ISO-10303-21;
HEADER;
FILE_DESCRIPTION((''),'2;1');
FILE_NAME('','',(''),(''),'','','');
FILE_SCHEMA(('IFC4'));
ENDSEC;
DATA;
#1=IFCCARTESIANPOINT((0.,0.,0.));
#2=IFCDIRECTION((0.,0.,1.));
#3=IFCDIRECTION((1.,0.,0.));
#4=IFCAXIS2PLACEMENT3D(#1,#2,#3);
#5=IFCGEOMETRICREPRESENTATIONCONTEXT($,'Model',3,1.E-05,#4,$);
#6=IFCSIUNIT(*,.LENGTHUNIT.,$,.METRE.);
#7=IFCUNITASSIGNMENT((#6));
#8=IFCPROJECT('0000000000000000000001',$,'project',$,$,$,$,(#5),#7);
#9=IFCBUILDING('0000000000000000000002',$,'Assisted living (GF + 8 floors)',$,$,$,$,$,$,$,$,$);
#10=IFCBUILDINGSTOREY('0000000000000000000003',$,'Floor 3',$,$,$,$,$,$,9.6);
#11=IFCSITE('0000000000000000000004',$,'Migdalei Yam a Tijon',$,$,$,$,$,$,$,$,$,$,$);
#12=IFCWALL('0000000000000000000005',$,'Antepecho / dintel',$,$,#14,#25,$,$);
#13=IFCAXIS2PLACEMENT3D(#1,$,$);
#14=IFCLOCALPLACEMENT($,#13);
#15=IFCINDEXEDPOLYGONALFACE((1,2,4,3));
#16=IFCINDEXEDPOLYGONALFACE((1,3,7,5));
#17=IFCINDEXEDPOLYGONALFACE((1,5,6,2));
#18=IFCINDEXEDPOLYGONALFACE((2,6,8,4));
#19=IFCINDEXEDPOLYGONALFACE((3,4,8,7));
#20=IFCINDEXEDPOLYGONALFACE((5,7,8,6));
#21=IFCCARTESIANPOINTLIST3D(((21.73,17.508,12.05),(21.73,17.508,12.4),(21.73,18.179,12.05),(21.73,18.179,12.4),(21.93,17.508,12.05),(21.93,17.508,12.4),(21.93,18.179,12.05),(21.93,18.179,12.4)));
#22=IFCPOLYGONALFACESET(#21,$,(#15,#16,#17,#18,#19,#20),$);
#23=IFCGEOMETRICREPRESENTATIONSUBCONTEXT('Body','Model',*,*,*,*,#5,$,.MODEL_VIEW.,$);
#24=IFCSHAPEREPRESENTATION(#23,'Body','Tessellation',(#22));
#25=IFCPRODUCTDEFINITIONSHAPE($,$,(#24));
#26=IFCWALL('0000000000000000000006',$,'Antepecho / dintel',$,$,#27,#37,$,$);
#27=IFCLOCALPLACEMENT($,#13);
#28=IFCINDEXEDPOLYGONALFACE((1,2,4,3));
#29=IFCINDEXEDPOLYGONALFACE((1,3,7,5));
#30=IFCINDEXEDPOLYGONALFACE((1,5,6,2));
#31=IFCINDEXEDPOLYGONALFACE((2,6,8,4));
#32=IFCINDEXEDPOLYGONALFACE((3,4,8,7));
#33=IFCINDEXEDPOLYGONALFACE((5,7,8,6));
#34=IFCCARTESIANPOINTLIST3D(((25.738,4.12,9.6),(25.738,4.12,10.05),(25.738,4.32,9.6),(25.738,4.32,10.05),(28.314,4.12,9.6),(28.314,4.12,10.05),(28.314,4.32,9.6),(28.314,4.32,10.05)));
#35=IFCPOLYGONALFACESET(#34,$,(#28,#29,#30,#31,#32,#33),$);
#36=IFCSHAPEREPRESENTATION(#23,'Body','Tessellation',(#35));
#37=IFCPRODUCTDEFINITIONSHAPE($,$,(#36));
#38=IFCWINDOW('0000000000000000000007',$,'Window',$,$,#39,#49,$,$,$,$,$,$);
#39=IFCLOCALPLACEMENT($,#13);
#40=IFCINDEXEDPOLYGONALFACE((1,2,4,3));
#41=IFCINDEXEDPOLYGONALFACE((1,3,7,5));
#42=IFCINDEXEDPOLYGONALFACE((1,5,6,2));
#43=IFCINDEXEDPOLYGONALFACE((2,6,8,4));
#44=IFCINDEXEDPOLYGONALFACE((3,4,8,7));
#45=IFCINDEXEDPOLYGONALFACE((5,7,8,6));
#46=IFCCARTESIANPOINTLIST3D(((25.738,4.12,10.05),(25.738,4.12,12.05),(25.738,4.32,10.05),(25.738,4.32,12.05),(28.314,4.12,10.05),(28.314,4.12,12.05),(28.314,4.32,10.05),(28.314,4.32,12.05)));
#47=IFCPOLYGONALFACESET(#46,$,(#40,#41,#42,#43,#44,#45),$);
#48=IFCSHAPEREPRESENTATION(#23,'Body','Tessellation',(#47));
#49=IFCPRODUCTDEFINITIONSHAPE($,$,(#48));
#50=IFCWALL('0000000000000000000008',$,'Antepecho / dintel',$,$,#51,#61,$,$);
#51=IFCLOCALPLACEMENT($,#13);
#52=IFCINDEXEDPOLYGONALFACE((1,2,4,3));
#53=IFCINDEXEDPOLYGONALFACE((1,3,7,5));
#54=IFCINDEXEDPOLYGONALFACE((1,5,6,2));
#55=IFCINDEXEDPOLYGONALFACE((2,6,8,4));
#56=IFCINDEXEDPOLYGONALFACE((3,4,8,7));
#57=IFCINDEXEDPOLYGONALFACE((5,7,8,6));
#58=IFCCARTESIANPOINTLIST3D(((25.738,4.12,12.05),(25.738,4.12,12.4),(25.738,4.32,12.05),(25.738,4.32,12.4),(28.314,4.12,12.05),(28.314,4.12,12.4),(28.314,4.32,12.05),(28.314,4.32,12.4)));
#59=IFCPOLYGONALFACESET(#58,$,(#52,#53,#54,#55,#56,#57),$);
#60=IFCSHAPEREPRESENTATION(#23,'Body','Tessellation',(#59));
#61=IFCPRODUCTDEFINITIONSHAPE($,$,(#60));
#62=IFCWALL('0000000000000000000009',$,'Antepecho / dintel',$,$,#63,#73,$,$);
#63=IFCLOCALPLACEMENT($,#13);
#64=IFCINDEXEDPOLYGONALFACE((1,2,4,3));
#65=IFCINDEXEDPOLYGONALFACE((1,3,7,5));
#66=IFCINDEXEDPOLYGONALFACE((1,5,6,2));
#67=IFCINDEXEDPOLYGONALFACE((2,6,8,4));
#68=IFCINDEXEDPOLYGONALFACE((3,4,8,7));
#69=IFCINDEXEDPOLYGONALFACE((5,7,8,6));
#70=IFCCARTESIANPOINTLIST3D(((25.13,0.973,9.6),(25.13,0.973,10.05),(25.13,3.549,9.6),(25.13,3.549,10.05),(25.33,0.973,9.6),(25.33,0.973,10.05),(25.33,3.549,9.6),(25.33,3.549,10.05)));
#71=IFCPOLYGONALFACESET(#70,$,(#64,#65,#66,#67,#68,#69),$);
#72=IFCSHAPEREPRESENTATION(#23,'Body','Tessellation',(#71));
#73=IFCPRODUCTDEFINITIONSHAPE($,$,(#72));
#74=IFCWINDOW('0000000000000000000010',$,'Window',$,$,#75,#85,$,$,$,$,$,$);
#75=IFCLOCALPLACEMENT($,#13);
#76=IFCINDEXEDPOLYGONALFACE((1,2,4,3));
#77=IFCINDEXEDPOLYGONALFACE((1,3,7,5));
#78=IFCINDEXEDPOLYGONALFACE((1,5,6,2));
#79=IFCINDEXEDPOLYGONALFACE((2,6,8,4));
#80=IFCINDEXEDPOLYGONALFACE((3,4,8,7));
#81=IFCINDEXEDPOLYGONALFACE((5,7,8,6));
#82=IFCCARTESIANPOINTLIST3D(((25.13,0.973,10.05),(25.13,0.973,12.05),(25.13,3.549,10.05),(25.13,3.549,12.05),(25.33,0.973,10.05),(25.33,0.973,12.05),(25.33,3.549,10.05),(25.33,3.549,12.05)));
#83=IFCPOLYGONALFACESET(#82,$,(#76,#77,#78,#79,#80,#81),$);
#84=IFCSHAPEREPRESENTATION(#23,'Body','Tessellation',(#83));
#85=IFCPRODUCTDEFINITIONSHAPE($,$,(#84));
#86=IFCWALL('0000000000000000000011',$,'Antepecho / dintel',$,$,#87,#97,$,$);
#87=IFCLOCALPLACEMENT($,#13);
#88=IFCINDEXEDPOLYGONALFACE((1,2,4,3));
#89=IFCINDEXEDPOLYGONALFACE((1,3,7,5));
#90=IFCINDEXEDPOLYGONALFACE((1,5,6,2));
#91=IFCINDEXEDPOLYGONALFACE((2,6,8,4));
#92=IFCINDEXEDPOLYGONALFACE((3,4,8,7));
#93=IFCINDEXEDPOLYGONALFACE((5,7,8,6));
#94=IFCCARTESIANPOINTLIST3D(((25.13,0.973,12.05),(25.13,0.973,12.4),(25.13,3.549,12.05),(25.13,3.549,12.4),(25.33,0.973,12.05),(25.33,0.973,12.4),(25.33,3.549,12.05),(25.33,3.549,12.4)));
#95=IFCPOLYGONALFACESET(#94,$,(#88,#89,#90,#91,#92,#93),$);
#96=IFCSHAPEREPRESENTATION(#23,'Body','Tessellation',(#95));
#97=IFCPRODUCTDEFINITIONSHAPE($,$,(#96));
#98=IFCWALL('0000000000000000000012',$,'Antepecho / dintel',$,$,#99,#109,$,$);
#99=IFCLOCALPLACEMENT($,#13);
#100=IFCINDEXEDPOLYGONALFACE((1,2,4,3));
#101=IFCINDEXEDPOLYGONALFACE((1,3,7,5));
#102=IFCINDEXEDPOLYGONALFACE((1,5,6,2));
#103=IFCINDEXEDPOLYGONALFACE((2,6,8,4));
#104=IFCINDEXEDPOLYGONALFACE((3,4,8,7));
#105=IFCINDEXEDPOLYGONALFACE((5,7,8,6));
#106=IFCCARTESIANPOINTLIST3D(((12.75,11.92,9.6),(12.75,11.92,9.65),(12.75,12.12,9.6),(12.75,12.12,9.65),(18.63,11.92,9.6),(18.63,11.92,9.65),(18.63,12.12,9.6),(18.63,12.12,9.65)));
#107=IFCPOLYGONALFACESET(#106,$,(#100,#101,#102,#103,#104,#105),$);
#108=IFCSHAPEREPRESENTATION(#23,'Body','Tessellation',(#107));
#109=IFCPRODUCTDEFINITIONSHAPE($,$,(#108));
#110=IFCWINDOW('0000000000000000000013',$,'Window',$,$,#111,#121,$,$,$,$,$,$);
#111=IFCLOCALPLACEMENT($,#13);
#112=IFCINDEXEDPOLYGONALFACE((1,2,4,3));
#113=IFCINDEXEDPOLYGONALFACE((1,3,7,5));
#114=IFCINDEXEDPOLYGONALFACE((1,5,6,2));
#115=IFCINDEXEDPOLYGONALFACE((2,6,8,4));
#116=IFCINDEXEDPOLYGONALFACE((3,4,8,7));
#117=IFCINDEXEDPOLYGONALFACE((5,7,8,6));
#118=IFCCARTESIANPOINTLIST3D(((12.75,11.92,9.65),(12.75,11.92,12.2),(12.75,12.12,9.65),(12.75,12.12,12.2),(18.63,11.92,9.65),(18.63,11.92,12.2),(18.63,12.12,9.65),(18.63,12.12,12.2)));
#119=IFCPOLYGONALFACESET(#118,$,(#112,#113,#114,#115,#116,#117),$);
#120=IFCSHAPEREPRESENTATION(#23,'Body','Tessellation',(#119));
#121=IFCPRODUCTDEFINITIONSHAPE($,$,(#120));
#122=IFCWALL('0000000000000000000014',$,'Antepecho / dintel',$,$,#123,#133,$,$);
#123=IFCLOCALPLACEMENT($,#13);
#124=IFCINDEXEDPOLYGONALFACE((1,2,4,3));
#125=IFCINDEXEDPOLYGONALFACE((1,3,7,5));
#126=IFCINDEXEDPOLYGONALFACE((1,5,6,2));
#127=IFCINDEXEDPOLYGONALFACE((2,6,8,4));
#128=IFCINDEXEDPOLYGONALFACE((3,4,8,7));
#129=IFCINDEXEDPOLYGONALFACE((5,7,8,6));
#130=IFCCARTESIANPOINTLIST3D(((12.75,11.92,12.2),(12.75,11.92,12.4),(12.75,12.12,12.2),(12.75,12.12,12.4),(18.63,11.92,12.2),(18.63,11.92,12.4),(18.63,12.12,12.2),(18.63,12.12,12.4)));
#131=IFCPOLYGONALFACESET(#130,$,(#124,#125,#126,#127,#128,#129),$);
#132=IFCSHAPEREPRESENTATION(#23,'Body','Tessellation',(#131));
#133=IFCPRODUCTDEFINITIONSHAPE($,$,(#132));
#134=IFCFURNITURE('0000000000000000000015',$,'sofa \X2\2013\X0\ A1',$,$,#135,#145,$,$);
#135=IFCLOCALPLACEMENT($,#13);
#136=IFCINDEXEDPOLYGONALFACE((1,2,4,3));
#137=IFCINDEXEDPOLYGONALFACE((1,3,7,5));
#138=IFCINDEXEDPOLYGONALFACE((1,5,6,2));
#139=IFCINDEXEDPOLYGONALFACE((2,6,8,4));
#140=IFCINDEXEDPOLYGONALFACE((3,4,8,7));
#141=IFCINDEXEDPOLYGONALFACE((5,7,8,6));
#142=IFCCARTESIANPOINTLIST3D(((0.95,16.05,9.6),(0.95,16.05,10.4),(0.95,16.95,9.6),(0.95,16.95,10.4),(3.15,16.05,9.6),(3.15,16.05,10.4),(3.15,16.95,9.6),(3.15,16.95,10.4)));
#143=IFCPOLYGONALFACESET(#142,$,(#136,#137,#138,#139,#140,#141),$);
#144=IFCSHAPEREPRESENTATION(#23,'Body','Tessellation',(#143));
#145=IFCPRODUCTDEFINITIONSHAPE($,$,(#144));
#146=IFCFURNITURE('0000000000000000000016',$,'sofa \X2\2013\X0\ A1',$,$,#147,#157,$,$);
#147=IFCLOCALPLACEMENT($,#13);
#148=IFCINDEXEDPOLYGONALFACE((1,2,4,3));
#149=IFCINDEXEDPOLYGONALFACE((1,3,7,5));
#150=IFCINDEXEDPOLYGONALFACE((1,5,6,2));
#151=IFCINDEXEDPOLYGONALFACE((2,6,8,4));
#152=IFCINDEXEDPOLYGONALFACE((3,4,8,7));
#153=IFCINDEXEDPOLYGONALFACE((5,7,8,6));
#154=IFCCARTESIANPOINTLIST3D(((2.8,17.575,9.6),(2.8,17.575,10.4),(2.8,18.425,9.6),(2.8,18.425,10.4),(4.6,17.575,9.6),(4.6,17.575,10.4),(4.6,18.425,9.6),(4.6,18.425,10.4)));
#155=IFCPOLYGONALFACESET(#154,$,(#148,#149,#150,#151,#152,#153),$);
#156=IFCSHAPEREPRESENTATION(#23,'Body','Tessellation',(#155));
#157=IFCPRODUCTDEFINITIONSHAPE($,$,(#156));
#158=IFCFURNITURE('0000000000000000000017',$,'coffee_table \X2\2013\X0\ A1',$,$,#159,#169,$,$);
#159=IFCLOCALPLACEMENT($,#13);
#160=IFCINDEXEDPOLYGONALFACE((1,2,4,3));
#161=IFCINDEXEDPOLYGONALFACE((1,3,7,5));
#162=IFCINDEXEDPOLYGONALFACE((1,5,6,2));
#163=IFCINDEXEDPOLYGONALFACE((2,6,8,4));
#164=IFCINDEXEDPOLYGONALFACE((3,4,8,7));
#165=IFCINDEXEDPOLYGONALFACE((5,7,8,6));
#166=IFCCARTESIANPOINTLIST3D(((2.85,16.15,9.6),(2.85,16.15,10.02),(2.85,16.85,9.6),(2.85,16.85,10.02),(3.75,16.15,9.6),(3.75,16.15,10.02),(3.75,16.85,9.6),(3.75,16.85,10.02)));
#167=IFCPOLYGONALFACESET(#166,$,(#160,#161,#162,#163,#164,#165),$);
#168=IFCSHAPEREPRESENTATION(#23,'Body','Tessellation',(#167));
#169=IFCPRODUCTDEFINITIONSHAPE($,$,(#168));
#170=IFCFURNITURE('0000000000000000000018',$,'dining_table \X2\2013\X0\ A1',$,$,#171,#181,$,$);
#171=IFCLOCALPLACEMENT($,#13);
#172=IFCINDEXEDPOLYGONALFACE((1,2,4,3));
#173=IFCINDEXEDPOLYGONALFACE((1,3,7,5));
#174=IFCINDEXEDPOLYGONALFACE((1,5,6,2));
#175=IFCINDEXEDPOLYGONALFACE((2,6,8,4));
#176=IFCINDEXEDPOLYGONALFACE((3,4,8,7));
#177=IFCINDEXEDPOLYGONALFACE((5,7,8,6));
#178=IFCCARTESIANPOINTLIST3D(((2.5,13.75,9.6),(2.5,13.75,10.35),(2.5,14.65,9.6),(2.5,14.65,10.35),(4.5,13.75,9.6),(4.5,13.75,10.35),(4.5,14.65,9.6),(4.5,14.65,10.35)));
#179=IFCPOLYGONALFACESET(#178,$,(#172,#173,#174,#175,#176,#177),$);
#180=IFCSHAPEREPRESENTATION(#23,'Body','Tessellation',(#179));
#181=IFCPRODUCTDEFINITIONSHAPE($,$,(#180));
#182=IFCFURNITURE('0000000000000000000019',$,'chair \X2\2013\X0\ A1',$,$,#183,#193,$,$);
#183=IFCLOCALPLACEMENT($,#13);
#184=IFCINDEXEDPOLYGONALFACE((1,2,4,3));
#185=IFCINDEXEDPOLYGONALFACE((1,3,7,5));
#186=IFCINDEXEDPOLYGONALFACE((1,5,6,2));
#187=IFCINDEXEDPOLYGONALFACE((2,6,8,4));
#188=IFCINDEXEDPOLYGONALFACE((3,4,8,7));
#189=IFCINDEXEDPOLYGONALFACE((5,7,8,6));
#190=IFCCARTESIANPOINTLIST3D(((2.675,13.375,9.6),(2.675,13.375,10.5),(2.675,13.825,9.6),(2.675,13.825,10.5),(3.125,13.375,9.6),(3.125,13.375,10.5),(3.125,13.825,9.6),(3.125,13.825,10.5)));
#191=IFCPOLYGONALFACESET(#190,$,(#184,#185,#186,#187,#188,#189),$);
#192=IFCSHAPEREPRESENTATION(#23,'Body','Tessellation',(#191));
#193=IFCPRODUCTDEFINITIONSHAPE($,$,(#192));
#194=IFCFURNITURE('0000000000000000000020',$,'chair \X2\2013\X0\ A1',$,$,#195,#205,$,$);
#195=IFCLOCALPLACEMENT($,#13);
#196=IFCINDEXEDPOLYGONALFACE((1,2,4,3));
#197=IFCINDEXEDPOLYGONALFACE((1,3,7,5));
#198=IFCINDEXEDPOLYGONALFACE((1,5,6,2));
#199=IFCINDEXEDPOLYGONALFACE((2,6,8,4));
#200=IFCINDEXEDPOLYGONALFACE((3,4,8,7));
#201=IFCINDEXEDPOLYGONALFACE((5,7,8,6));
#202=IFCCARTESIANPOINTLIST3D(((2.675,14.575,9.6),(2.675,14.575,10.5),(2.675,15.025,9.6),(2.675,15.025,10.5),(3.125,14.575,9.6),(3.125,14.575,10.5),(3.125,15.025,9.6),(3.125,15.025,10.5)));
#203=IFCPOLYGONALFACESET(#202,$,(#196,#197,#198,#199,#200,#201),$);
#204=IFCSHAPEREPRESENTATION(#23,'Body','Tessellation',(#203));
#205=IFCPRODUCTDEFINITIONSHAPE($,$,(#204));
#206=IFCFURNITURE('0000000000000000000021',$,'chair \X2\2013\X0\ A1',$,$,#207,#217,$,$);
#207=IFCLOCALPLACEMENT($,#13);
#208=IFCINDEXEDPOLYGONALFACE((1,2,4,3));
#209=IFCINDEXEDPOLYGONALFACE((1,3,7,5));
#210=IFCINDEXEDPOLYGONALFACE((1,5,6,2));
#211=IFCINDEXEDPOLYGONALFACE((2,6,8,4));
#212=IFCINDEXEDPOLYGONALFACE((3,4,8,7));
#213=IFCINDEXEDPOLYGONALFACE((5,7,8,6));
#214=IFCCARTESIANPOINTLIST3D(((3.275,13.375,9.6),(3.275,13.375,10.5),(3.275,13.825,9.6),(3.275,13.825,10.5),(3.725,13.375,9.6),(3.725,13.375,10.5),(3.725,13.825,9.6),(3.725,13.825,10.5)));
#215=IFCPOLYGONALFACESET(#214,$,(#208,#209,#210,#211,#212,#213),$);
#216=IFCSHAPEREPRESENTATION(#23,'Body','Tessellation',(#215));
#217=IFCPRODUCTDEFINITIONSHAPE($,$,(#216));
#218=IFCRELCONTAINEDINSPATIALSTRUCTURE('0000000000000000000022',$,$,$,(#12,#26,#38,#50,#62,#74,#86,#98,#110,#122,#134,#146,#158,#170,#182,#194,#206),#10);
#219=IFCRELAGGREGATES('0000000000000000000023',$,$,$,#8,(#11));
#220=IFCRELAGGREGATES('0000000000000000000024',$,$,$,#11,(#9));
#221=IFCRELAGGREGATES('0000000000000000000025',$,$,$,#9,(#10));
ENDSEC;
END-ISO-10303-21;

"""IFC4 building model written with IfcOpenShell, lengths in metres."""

from ifc_helpers import new_model, si_unit, frame, origin_with_axes, context, subcontext, project, spatial, line, indexed_curve, outline, extrude, element, save


model = new_model("IFC4")

# Units and contexts
model_context = context("Model", 3, precision=1e-05, world=origin_with_axes())
body_context = subcontext(model_context, "Body", "Model", "MODEL_VIEW")
ifc_project = project(units=[si_unit("LENGTHUNIT", "METRE")], contexts=[model_context])

# Site, building, storey
site = spatial("IfcSite", under=ifc_project, Name="Migdalei Yam a Tijon")
building = spatial("IfcBuilding", under=site, Name="Assisted living (GF + 8 floors)")
storey = spatial("IfcBuildingStorey", under=building, Name="Floor 3", Elevation=9.6)

# Walls
element("IfcWall", 1, inside=storey, Name="Antepecho / dintel", context=body_context, shape_type="SweptSolid", body=[
    extrude(outline(indexed_curve([(0.0, 0.0), (0.2, 0.0), (0.2, 0.671), (0.0, 0.671)], segments=[line(1, 2, 3, 4, 1)])), frame((21.73, 17.508, 12.05), z_axis=(0.0, 0.0, 1.0), x_axis=(1.0, 0.0, 0.0)), (0.0, 0.0, 1.0), 0.35),
])
element("IfcWall", 2, inside=storey, Name="Antepecho / dintel", context=body_context, shape_type="SweptSolid", body=[
    extrude(outline(indexed_curve([(0.0, 0.0), (2.576, 0.0), (2.576, 0.2), (0.0, 0.2)], segments=[line(1, 2, 3, 4, 1)])), frame((25.738, 4.12, 9.6), z_axis=(0.0, 0.0, 1.0), x_axis=(1.0, 0.0, 0.0)), (0.0, 0.0, 1.0), 0.45),
])

# Window
element("IfcWindow", 3, inside=storey, Name="Window", context=body_context, shape_type="SweptSolid", body=[
    extrude(outline(indexed_curve([(0.0, 0.0), (2.576, 0.0), (2.576, 0.2), (0.0, 0.2)], segments=[line(1, 2, 3, 4, 1)])), frame((25.738, 4.12, 10.05), z_axis=(0.0, 0.0, 1.0), x_axis=(1.0, 0.0, 0.0)), (0.0, 0.0, 1.0), 2.0),
])

# Walls
element("IfcWall", 4, inside=storey, Name="Antepecho / dintel", context=body_context, shape_type="SweptSolid", body=[
    extrude(outline(indexed_curve([(0.0, 0.0), (2.576, 0.0), (2.576, 0.2), (0.0, 0.2)], segments=[line(1, 2, 3, 4, 1)])), frame((25.738, 4.12, 12.05), z_axis=(0.0, 0.0, 1.0), x_axis=(1.0, 0.0, 0.0)), (0.0, 0.0, 1.0), 0.35),
])
element("IfcWall", 5, inside=storey, Name="Antepecho / dintel", context=body_context, shape_type="SweptSolid", body=[
    extrude(outline(indexed_curve([(0.0, 0.0), (0.2, 0.0), (0.2, 2.576), (0.0, 2.576)], segments=[line(1, 2, 3, 4, 1)])), frame((25.13, 0.973, 9.6), z_axis=(0.0, 0.0, 1.0), x_axis=(1.0, 0.0, 0.0)), (0.0, 0.0, 1.0), 0.45),
])

# Window
element("IfcWindow", 6, inside=storey, Name="Window", context=body_context, shape_type="SweptSolid", body=[
    extrude(outline(indexed_curve([(0.0, 0.0), (0.2, 0.0), (0.2, 2.576), (0.0, 2.576)], segments=[line(1, 2, 3, 4, 1)])), frame((25.13, 0.973, 10.05), z_axis=(0.0, 0.0, 1.0), x_axis=(1.0, 0.0, 0.0)), (0.0, 0.0, 1.0), 2.0),
])

# Walls
element("IfcWall", 7, inside=storey, Name="Antepecho / dintel", context=body_context, shape_type="SweptSolid", body=[
    extrude(outline(indexed_curve([(0.0, 0.0), (0.2, 0.0), (0.2, 2.576), (0.0, 2.576)], segments=[line(1, 2, 3, 4, 1)])), frame((25.13, 0.973, 12.05), z_axis=(0.0, 0.0, 1.0), x_axis=(1.0, 0.0, 0.0)), (0.0, 0.0, 1.0), 0.35),
])
element("IfcWall", 8, inside=storey, Name="Antepecho / dintel", context=body_context, shape_type="SweptSolid", body=[
    extrude(outline(indexed_curve([(0.0, 0.0), (5.88, 0.0), (5.88, 0.2), (0.0, 0.2)], segments=[line(1, 2, 3, 4, 1)])), frame((12.75, 11.92, 9.6), z_axis=(0.0, 0.0, 1.0), x_axis=(1.0, 0.0, 0.0)), (0.0, 0.0, 1.0), 0.05),
])

# Window
element("IfcWindow", 9, inside=storey, Name="Window", context=body_context, shape_type="SweptSolid", body=[
    extrude(outline(indexed_curve([(0.0, 0.0), (5.88, 0.0), (5.88, 0.2), (0.0, 0.2)], segments=[line(1, 2, 3, 4, 1)])), frame((12.75, 11.92, 9.65), z_axis=(0.0, 0.0, 1.0), x_axis=(1.0, 0.0, 0.0)), (0.0, 0.0, 1.0), 2.55),
])

# Wall
element("IfcWall", 10, inside=storey, Name="Antepecho / dintel", context=body_context, shape_type="SweptSolid", body=[
    extrude(outline(indexed_curve([(0.0, 0.0), (5.88, 0.0), (5.88, 0.2), (0.0, 0.2)], segments=[line(1, 2, 3, 4, 1)])), frame((12.75, 11.92, 12.2), z_axis=(0.0, 0.0, 1.0), x_axis=(1.0, 0.0, 0.0)), (0.0, 0.0, 1.0), 0.2),
])

# Furniture
element("IfcFurniture", 11, inside=storey, Name="sofa – A1", context=body_context, shape_type="SweptSolid", body=[
    extrude(outline(indexed_curve([(0.0, 0.0), (2.2, 0.0), (2.2, 0.9), (0.0, 0.9)], segments=[line(1, 2, 3, 4, 1)])), frame((0.95, 16.05, 9.6), z_axis=(0.0, 0.0, 1.0), x_axis=(1.0, 0.0, 0.0)), (0.0, 0.0, 1.0), 0.8),
])
element("IfcFurniture", 12, inside=storey, Name="sofa – A1", context=body_context, shape_type="SweptSolid", body=[
    extrude(outline(indexed_curve([(0.0, 0.0), (1.8, 0.0), (1.8, 0.85), (0.0, 0.85)], segments=[line(1, 2, 3, 4, 1)])), frame((2.8, 17.575, 9.6), z_axis=(0.0, 0.0, 1.0), x_axis=(1.0, 0.0, 0.0)), (0.0, 0.0, 1.0), 0.8),
])
element("IfcFurniture", 13, inside=storey, Name="coffee_table – A1", context=body_context, shape_type="SweptSolid", body=[
    extrude(outline(indexed_curve([(0.0, 0.0), (0.9, 0.0), (0.9, 0.7), (0.0, 0.7)], segments=[line(1, 2, 3, 4, 1)])), frame((2.85, 16.15, 9.6), z_axis=(0.0, 0.0, 1.0), x_axis=(1.0, 0.0, 0.0)), (0.0, 0.0, 1.0), 0.42),
])
element("IfcFurniture", 14, inside=storey, Name="dining_table – A1", context=body_context, shape_type="SweptSolid", body=[
    extrude(outline(indexed_curve([(0.0, 0.0), (2.0, 0.0), (2.0, 0.9), (0.0, 0.9)], segments=[line(1, 2, 3, 4, 1)])), frame((2.5, 13.75, 9.6), z_axis=(0.0, 0.0, 1.0), x_axis=(1.0, 0.0, 0.0)), (0.0, 0.0, 1.0), 0.75),
])
element("IfcFurniture", 15, inside=storey, Name="chair – A1", context=body_context, shape_type="SweptSolid", body=[
    extrude(outline(indexed_curve([(0.0, 0.0), (0.45, 0.0), (0.45, 0.45), (0.0, 0.45)], segments=[line(1, 2, 3, 4, 1)])), frame((2.675, 13.375, 9.6), z_axis=(0.0, 0.0, 1.0), x_axis=(1.0, 0.0, 0.0)), (0.0, 0.0, 1.0), 0.9),
])
element("IfcFurniture", 16, inside=storey, Name="chair – A1", context=body_context, shape_type="SweptSolid", body=[
    extrude(outline(indexed_curve([(0.0, 0.0), (0.45, 0.0), (0.45, 0.45), (0.0, 0.45)], segments=[line(1, 2, 3, 4, 1)])), frame((2.675, 14.575, 9.6), z_axis=(0.0, 0.0, 1.0), x_axis=(1.0, 0.0, 0.0)), (0.0, 0.0, 1.0), 0.9),
])
element("IfcFurniture", 17, inside=storey, Name="chair – A1", context=body_context, shape_type="SweptSolid", body=[
    extrude(outline(indexed_curve([(0.0, 0.0), (0.45, 0.0), (0.45, 0.45), (0.0, 0.45)], segments=[line(1, 2, 3, 4, 1)])), frame((3.275, 13.375, 9.6), z_axis=(0.0, 0.0, 1.0), x_axis=(1.0, 0.0, 0.0)), (0.0, 0.0, 1.0), 0.9),
])

save(model, "model.ifc")
